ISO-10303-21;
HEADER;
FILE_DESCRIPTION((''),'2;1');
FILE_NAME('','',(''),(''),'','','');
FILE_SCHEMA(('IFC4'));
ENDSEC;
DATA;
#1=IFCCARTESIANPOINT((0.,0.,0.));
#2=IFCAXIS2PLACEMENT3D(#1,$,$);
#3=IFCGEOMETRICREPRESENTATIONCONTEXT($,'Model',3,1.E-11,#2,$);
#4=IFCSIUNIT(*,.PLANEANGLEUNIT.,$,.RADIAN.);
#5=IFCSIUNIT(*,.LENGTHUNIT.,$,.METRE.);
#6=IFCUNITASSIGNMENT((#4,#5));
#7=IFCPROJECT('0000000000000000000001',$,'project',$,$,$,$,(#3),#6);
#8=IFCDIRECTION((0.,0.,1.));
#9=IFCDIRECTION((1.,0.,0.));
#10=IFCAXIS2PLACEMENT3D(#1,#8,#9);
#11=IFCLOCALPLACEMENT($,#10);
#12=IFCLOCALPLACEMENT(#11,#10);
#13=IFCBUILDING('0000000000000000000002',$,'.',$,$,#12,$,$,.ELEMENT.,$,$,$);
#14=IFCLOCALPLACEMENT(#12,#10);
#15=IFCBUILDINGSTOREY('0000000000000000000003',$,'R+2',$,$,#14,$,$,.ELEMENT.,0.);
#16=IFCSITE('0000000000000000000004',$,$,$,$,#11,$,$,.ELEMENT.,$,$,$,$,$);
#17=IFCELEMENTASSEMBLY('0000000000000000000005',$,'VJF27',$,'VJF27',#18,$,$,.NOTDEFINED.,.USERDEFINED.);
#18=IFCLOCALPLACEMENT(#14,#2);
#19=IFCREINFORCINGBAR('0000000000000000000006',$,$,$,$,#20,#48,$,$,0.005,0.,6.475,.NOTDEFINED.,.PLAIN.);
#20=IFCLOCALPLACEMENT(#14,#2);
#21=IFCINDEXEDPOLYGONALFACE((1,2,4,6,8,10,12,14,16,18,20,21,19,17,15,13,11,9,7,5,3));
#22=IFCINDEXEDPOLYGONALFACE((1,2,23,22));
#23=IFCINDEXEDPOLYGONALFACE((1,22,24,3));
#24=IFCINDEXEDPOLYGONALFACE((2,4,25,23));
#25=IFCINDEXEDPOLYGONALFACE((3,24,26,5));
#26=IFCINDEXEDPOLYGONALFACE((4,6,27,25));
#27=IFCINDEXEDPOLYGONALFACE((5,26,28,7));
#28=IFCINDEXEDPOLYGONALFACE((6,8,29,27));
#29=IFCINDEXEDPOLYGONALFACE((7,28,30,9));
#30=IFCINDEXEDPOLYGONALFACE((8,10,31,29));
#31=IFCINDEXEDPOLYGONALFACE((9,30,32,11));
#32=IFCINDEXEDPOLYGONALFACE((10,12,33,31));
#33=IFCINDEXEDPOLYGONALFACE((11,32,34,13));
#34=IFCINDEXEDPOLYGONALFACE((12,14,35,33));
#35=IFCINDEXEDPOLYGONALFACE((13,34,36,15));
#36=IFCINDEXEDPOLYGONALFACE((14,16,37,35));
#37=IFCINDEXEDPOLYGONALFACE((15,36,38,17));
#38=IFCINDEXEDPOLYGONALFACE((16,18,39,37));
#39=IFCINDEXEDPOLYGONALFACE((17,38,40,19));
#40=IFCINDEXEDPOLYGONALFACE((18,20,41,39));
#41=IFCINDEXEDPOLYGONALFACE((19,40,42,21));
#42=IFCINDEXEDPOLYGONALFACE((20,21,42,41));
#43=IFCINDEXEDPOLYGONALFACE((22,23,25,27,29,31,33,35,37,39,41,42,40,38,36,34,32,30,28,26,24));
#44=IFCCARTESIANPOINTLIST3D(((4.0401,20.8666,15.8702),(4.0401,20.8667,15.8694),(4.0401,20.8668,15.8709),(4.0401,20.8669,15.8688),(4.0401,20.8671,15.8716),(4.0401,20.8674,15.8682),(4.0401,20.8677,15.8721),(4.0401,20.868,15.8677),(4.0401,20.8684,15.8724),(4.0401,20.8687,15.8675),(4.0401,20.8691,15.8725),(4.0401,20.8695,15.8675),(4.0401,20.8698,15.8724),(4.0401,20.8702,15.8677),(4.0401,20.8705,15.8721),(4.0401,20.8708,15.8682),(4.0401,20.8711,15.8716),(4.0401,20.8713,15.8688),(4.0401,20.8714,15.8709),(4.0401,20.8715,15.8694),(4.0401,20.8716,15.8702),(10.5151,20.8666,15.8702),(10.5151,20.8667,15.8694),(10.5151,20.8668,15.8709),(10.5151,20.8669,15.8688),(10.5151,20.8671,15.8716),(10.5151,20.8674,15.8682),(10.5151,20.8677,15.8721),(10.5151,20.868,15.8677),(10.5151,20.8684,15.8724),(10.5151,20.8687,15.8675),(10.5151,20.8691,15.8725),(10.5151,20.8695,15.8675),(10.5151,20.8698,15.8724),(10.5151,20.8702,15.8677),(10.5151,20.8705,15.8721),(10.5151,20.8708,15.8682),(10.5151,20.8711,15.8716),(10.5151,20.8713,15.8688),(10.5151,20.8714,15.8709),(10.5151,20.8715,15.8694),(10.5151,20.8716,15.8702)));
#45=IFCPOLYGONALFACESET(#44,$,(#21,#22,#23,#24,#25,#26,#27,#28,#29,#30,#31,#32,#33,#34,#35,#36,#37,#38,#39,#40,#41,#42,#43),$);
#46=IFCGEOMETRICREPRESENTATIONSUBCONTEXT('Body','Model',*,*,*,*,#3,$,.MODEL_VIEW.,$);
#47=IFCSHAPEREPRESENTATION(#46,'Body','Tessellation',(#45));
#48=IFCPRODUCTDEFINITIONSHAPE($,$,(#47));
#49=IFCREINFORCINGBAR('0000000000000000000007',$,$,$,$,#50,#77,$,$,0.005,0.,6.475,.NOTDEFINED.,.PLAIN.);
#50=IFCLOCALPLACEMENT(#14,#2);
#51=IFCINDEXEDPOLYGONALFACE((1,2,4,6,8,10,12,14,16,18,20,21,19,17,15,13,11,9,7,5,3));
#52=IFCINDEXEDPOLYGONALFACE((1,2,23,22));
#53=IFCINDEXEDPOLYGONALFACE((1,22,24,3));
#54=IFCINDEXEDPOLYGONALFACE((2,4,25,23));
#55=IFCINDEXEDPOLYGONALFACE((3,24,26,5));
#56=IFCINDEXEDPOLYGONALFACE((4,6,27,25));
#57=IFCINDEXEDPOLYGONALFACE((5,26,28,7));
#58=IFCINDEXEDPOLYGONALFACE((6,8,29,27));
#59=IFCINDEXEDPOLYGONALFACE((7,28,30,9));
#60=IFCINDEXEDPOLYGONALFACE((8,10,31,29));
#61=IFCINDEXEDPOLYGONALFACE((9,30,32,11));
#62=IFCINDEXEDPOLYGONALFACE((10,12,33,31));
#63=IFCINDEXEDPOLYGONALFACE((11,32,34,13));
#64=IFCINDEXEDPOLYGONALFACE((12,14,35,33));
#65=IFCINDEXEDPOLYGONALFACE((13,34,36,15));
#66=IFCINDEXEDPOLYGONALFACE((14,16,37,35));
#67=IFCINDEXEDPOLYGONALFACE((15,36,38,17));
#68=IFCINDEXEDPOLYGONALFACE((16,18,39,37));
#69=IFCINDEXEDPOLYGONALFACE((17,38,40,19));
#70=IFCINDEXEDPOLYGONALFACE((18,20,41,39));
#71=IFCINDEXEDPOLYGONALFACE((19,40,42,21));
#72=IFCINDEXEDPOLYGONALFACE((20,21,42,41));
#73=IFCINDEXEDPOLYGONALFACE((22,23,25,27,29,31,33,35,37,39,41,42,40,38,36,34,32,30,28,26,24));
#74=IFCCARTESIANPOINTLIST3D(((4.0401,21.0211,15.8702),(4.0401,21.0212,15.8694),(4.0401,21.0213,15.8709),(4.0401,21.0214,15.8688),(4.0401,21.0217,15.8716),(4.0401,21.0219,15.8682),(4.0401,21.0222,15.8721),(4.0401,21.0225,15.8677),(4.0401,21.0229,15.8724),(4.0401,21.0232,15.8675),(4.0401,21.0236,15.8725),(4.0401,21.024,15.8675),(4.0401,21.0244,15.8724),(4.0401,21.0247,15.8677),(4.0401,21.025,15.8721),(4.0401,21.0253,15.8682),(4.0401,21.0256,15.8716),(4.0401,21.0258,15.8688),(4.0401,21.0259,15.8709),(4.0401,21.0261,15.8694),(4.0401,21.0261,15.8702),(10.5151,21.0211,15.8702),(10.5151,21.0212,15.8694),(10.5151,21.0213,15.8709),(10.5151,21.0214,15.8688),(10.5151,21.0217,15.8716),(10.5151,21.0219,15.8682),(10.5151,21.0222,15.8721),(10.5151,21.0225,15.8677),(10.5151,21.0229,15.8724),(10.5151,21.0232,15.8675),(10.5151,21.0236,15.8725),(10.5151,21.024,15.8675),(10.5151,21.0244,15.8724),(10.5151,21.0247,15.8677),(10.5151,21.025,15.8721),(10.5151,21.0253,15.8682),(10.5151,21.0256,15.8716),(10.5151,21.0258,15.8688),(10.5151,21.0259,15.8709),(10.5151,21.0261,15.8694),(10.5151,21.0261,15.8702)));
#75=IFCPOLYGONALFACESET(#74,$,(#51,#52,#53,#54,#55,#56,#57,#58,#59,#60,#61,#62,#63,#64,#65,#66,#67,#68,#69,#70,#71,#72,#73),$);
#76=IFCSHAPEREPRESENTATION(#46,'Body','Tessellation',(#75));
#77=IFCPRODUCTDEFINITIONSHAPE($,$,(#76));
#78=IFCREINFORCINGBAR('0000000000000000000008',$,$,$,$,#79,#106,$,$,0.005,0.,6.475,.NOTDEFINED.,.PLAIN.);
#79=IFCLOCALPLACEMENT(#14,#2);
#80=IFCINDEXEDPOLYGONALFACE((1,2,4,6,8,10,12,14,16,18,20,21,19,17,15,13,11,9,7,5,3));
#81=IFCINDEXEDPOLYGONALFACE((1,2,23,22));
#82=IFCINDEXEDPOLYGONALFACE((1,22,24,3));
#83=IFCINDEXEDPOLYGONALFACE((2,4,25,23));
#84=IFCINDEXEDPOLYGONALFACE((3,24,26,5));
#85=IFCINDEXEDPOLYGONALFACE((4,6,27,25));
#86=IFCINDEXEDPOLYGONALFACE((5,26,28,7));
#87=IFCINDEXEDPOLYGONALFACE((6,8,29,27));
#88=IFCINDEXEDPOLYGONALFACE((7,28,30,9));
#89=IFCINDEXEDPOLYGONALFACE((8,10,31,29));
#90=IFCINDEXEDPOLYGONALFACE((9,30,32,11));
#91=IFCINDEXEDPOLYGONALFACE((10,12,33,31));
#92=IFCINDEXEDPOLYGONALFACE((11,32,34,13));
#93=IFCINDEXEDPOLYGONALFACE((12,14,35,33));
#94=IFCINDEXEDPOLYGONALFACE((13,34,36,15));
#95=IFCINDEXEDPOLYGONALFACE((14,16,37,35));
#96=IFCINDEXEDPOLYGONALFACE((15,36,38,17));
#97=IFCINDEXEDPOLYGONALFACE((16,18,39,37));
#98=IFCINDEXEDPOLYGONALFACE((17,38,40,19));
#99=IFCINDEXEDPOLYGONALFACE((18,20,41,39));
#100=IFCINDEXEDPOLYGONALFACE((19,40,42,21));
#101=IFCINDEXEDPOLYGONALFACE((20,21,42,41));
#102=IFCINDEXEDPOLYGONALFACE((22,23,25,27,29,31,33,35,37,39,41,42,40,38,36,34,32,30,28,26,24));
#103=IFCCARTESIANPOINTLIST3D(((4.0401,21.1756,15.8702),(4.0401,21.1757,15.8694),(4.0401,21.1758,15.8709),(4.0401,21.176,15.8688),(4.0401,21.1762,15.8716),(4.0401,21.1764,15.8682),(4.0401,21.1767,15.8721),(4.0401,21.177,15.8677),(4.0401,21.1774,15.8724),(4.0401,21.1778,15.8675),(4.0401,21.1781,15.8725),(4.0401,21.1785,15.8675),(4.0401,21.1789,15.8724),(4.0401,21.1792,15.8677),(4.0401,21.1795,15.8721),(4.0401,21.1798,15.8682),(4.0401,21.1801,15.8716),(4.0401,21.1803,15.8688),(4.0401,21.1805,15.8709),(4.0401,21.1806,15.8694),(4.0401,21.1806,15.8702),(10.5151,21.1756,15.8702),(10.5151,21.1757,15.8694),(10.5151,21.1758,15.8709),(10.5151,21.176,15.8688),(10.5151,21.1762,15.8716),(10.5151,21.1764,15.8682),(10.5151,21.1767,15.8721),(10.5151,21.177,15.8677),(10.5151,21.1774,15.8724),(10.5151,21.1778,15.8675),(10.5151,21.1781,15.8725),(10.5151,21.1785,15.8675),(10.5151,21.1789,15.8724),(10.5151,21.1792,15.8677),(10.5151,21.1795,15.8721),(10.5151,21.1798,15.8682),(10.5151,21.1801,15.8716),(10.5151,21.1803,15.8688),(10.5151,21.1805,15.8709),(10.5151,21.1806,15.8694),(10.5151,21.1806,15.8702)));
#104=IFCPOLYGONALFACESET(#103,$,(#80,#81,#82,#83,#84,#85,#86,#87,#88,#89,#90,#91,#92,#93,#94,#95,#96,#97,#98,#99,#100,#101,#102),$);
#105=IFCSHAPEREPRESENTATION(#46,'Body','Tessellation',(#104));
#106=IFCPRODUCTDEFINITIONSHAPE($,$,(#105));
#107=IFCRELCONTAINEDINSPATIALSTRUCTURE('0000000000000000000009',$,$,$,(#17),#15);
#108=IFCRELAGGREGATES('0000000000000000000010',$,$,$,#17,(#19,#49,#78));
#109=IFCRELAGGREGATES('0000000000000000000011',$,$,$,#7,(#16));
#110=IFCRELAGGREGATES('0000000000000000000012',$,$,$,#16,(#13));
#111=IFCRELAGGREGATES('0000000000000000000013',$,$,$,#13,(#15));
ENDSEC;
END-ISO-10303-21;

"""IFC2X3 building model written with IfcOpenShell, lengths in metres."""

from ifc_helpers import new_model, entity, si_unit, origin, origin_with_axes, place, context, subcontext, project, spatial, shape, element, aggregate, save


model = new_model("IFC2X3")

# Units and contexts
model_context = context("Model", 3, precision=1e-11, world=origin())
body_context = subcontext(model_context, "Body", "Model", "MODEL_VIEW")
ifc_project = project(units=[si_unit("PLANEANGLEUNIT", "RADIAN"), si_unit("LENGTHUNIT", "METRE")], contexts=[model_context])

# Site, building, storey
site_placement = place(None, origin_with_axes())
site = spatial("IfcSite", under=ifc_project, at=site_placement, CompositionType="ELEMENT")
building_placement = place(site_placement, origin_with_axes())
building = spatial("IfcBuilding", under=site, at=building_placement, Name=".", CompositionType="ELEMENT")
storey_placement = place(building_placement, origin_with_axes())
storey = spatial("IfcBuildingStorey", under=building, at=storey_placement, Name="R+2", CompositionType="ELEMENT", Elevation=0.0)

# Element assembly, reinforcing bars
assembly_1_placement = place(storey_placement, origin_with_axes())
assembly_1 = element("IfcElementAssembly", 1, at=assembly_1_placement, inside=storey, Name="VJF27", ObjectType="VJF27", AssemblyPlace="NOTDEFINED", PredefinedType="USERDEFINED")
reinforcing_bar_1_placement = place(assembly_1_placement, origin_with_axes())
reinforcing_bar_1 = element("IfcReinforcingBar", 2, at=reinforcing_bar_1_placement, BarLength=6.475, BarRole="NOTDEFINED", BarSurface="PLAIN", CrossSectionArea=0.0, NominalDiameter=0.005, shapes=[
    shape(body_context, "Body", "AdvancedSweptSolid", [entity("IfcSweptDiskSolid", entity("IfcPolyline", [entity("IfcCartesianPoint", [4.0401, 20.8691, 15.87]), entity("IfcCartesianPoint", [10.5151, 20.8691, 15.87])]), 0.0025, None, 0.0, 6.475)]),
    shape(body_context, "Body", "AdvancedSweptSolid", [entity("IfcSweptDiskSolid", entity("IfcPolyline", [entity("IfcCartesianPoint", [4.0401, 20.8691, 15.87]), entity("IfcCartesianPoint", [10.5151, 20.8691, 15.87])]), 0.0025, None, 0.0, 6.475)]),
])
reinforcing_bar_2_placement = place(assembly_1_placement, origin_with_axes())
reinforcing_bar_2 = element("IfcReinforcingBar", 3, at=reinforcing_bar_2_placement, BarLength=6.475, BarRole="NOTDEFINED", BarSurface="PLAIN", CrossSectionArea=0.0, NominalDiameter=0.005, shapes=[
    shape(body_context, "Body", "AdvancedSweptSolid", [entity("IfcSweptDiskSolid", entity("IfcPolyline", [entity("IfcCartesianPoint", [4.0401, 21.0236, 15.87]), entity("IfcCartesianPoint", [10.5151, 21.0236, 15.87])]), 0.0025, None, 0.0, 6.475)]),
    shape(body_context, "Body", "AdvancedSweptSolid", [entity("IfcSweptDiskSolid", entity("IfcPolyline", [entity("IfcCartesianPoint", [4.0401, 21.0236, 15.87]), entity("IfcCartesianPoint", [10.5151, 21.0236, 15.87])]), 0.0025, None, 0.0, 6.475)]),
])
reinforcing_bar_3_placement = place(assembly_1_placement, origin_with_axes())
reinforcing_bar_3 = element("IfcReinforcingBar", 4, at=reinforcing_bar_3_placement, BarLength=6.475, BarRole="NOTDEFINED", BarSurface="PLAIN", CrossSectionArea=0.0, NominalDiameter=0.005, shapes=[
    shape(body_context, "Body", "AdvancedSweptSolid", [entity("IfcSweptDiskSolid", entity("IfcPolyline", [entity("IfcCartesianPoint", [4.0401, 21.1781, 15.87]), entity("IfcCartesianPoint", [10.5151, 21.1781, 15.87])]), 0.0025, None, 0.0, 6.475)]),
    shape(body_context, "Body", "AdvancedSweptSolid", [entity("IfcSweptDiskSolid", entity("IfcPolyline", [entity("IfcCartesianPoint", [4.0401, 21.1781, 15.87]), entity("IfcCartesianPoint", [10.5151, 21.1781, 15.87])]), 0.0025, None, 0.0, 6.475)]),
])
aggregate(assembly_1, [reinforcing_bar_1, reinforcing_bar_2, reinforcing_bar_3])

save(model, "model.ifc")
